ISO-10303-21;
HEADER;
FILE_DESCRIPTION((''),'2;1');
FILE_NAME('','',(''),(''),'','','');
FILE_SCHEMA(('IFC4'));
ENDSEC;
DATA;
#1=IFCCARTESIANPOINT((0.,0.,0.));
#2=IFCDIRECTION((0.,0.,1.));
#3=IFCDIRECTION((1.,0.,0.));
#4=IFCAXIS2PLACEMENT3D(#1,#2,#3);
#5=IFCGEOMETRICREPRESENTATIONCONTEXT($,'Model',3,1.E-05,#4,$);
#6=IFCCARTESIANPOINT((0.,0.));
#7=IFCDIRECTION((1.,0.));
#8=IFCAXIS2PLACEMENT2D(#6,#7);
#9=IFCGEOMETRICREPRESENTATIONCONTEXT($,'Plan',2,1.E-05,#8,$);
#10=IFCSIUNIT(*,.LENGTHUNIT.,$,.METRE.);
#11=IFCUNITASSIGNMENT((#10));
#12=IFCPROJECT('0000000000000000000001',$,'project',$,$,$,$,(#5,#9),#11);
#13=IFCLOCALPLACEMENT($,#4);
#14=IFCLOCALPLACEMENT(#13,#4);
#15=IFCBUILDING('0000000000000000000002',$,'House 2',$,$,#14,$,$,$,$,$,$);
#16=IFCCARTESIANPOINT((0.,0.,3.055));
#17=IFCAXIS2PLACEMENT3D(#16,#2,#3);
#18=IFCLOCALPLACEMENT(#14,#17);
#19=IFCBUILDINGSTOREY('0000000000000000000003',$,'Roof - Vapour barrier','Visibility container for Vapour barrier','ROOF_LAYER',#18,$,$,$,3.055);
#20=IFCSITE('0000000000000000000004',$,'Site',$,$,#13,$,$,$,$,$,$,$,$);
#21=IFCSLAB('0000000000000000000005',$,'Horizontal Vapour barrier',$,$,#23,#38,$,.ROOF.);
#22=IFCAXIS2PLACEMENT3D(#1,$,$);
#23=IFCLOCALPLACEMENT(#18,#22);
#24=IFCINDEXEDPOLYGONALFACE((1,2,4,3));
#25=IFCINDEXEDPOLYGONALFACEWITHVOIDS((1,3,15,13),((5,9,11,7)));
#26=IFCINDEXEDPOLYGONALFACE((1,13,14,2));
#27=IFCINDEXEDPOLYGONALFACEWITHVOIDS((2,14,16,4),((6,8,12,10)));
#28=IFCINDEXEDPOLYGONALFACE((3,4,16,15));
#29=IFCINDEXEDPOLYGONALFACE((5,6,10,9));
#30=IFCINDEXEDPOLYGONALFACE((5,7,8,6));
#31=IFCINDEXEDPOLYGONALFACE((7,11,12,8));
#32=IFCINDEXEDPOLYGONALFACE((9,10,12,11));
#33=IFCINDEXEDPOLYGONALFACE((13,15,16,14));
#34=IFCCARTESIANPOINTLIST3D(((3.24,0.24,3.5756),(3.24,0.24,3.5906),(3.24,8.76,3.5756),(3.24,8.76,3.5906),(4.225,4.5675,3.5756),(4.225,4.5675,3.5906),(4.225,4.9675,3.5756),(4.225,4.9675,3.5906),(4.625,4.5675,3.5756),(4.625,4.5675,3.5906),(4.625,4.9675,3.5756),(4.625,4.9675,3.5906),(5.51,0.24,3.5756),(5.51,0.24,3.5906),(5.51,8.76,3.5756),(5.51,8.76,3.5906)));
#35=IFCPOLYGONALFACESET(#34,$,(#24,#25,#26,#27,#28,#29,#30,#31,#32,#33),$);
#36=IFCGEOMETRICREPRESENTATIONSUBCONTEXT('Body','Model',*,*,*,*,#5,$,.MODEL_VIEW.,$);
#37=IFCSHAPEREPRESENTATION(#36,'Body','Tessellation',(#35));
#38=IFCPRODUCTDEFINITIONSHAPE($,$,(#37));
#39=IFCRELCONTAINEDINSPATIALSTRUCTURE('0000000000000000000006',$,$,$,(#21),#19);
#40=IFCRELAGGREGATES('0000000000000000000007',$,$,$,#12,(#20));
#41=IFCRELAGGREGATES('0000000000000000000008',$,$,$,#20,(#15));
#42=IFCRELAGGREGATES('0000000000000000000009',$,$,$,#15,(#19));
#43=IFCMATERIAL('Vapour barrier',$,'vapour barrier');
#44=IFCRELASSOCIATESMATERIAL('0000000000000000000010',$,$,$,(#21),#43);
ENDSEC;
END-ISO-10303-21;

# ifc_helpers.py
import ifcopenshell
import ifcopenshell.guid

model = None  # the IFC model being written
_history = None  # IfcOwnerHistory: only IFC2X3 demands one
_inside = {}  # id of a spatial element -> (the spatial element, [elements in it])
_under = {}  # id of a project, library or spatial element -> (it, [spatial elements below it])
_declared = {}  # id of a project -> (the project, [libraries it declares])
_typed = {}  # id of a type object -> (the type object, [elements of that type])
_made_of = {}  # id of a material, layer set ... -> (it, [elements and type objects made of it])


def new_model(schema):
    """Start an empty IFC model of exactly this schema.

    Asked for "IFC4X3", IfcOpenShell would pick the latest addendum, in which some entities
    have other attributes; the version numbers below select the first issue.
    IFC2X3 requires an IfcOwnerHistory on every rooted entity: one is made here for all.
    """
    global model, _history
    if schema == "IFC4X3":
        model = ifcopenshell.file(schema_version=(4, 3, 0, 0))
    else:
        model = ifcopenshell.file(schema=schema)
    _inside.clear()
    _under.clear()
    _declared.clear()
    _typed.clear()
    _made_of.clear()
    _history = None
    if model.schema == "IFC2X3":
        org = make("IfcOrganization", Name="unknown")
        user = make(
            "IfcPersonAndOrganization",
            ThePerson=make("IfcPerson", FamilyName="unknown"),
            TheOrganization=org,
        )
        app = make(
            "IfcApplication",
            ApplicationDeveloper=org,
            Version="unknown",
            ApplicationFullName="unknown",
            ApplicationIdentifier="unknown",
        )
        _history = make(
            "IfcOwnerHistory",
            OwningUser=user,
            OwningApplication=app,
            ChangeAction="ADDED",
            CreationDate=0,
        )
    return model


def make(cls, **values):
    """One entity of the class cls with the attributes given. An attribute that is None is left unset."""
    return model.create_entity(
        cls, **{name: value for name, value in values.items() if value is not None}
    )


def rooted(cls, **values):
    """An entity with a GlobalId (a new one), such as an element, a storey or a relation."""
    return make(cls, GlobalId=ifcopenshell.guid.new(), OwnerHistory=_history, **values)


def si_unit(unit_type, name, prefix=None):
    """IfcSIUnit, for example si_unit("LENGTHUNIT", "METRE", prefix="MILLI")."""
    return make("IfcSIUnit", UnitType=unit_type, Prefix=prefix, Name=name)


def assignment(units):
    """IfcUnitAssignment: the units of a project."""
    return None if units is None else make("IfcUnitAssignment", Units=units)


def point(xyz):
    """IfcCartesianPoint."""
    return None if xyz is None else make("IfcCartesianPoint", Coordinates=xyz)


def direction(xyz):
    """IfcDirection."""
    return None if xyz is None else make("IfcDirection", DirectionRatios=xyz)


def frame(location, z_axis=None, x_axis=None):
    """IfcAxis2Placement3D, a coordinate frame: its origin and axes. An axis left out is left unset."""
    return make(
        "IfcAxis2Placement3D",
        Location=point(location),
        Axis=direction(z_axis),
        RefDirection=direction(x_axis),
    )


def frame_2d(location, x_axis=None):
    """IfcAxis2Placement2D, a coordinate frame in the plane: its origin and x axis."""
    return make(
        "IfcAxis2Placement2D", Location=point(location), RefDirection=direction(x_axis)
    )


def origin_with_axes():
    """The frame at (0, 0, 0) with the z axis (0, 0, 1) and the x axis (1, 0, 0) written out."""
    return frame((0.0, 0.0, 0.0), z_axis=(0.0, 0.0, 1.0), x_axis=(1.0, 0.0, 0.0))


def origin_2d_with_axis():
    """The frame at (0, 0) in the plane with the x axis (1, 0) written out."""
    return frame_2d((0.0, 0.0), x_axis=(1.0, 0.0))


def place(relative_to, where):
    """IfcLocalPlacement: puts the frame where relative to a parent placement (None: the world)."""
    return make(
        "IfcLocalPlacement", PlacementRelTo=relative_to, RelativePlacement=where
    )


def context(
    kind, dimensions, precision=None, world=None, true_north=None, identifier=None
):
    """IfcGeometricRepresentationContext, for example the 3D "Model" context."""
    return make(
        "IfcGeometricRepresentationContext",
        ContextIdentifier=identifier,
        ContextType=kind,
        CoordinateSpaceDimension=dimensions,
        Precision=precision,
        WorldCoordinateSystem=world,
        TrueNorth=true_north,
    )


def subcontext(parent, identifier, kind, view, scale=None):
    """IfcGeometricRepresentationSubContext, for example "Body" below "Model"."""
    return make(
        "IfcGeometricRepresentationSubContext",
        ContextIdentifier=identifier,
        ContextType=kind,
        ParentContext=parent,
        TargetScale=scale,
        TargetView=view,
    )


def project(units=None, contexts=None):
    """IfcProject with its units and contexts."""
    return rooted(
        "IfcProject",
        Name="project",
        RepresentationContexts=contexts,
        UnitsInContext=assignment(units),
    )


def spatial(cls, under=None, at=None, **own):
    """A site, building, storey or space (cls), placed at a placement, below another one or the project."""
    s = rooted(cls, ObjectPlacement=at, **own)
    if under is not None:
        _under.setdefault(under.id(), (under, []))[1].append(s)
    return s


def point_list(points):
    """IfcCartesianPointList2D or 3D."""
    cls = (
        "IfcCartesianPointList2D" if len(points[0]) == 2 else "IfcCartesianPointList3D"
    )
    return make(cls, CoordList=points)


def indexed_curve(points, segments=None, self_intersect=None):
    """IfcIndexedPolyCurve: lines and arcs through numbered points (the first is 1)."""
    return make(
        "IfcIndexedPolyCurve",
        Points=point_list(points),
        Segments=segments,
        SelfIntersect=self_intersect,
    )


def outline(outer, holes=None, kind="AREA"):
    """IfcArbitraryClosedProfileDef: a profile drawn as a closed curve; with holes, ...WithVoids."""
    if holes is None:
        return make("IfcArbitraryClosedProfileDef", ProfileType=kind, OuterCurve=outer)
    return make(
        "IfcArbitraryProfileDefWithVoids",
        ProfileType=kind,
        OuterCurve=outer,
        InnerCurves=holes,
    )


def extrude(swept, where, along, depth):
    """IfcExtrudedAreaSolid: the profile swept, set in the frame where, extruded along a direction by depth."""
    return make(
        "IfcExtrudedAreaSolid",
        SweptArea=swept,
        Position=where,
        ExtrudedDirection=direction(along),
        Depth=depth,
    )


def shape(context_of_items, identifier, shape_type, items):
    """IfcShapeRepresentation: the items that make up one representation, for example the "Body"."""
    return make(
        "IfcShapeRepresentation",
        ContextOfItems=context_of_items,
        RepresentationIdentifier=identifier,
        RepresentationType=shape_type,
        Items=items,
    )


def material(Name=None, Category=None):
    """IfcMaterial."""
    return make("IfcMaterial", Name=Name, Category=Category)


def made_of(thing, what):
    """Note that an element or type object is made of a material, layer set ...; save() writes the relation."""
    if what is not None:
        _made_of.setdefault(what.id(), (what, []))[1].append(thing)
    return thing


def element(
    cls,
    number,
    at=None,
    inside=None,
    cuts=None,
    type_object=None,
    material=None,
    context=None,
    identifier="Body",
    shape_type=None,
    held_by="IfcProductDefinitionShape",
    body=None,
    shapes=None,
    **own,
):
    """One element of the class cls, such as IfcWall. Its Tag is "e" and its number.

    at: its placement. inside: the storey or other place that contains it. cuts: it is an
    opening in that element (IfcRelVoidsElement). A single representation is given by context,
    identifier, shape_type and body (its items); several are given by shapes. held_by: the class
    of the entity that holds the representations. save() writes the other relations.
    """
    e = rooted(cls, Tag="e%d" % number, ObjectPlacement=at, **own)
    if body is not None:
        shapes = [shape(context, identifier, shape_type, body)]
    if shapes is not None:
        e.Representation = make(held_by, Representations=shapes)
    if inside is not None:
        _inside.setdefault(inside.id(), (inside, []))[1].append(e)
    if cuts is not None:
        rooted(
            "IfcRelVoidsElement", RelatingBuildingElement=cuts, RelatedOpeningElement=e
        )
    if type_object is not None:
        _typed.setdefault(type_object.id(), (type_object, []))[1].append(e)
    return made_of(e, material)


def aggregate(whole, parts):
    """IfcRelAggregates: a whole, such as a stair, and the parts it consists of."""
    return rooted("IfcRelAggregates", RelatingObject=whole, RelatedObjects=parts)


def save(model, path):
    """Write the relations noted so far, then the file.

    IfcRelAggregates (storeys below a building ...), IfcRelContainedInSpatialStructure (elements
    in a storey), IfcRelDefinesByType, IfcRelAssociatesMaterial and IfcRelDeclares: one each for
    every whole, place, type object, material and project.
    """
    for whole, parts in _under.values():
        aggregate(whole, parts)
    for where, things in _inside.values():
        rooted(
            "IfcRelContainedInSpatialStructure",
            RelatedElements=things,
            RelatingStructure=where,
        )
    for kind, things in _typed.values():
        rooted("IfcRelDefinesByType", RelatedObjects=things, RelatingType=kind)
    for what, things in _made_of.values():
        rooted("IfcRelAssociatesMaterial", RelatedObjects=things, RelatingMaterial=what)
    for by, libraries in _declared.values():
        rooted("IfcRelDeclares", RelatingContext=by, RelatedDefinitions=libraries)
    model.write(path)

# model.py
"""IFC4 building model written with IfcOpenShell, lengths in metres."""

from ifc_helpers import new_model, si_unit, frame, origin_with_axes, origin_2d_with_axis, place, context, subcontext, project, spatial, indexed_curve, outline, extrude, material, element, save


model = new_model("IFC4")

# Units and contexts
model_context = context("Model", 3, precision=1e-05, world=origin_with_axes())
plan_context = context("Plan", 2, precision=1e-05, world=origin_2d_with_axis())
body_context = subcontext(model_context, "Body", "Model", "MODEL_VIEW")
ifc_project = project(units=[si_unit("LENGTHUNIT", "METRE")], contexts=[model_context, plan_context])

# Site, building, storey
site_placement = place(None, origin_with_axes())
site = spatial("IfcSite", under=ifc_project, at=site_placement, Name="Site")
building_placement = place(site_placement, origin_with_axes())
building = spatial("IfcBuilding", under=site, at=building_placement, Name="House 2")
storey_placement = place(building_placement, frame((0.0, 0.0, 3.055), z_axis=(0.0, 0.0, 1.0), x_axis=(1.0, 0.0, 0.0)))
storey = spatial("IfcBuildingStorey", under=building, at=storey_placement, Name="Roof - Vapour barrier", Description="Visibility container for Vapour barrier", ObjectType="ROOF_LAYER", Elevation=3.055)

# Slab, opening
ifc_material = material(Name="Vapour barrier", Category="vapour barrier")
slab_1_placement = place(storey_placement, frame((0.0, 0.0, 3.5756), z_axis=(0.0, 0.0, 1.0), x_axis=(1.0, 0.0, 0.0)))
slab_1 = element("IfcSlab", 1, at=slab_1_placement, inside=storey, material=ifc_material, Name="Horizontal Vapour barrier", PredefinedType="ROOF", context=body_context, shape_type="SweptSolid", body=[
    extrude(outline(indexed_curve([(3.24, 0.24), (5.51, 0.24), (5.51, 8.76), (3.24, 8.76)])), None, (0.0, 0.0, 1.0), 0.015),
])
opening_1_placement = place(slab_1_placement, frame((0.0, 0.0, -0.05), z_axis=(0.0, 0.0, 1.0), x_axis=(1.0, 0.0, 0.0)))
element("IfcOpeningElement", 2, at=opening_1_placement, cuts=slab_1, ObjectType="ROOF_OPENING", PredefinedType="OPENING", context=body_context, shape_type="SweptSolid", body=[
    extrude(outline(indexed_curve([(4.225, 4.5675), (4.625, 4.5675), (4.625, 4.9675), (4.225, 4.9675)])), None, (0.0, 0.0, 1.0), 0.115),
])

save(model, "model.ifc")
